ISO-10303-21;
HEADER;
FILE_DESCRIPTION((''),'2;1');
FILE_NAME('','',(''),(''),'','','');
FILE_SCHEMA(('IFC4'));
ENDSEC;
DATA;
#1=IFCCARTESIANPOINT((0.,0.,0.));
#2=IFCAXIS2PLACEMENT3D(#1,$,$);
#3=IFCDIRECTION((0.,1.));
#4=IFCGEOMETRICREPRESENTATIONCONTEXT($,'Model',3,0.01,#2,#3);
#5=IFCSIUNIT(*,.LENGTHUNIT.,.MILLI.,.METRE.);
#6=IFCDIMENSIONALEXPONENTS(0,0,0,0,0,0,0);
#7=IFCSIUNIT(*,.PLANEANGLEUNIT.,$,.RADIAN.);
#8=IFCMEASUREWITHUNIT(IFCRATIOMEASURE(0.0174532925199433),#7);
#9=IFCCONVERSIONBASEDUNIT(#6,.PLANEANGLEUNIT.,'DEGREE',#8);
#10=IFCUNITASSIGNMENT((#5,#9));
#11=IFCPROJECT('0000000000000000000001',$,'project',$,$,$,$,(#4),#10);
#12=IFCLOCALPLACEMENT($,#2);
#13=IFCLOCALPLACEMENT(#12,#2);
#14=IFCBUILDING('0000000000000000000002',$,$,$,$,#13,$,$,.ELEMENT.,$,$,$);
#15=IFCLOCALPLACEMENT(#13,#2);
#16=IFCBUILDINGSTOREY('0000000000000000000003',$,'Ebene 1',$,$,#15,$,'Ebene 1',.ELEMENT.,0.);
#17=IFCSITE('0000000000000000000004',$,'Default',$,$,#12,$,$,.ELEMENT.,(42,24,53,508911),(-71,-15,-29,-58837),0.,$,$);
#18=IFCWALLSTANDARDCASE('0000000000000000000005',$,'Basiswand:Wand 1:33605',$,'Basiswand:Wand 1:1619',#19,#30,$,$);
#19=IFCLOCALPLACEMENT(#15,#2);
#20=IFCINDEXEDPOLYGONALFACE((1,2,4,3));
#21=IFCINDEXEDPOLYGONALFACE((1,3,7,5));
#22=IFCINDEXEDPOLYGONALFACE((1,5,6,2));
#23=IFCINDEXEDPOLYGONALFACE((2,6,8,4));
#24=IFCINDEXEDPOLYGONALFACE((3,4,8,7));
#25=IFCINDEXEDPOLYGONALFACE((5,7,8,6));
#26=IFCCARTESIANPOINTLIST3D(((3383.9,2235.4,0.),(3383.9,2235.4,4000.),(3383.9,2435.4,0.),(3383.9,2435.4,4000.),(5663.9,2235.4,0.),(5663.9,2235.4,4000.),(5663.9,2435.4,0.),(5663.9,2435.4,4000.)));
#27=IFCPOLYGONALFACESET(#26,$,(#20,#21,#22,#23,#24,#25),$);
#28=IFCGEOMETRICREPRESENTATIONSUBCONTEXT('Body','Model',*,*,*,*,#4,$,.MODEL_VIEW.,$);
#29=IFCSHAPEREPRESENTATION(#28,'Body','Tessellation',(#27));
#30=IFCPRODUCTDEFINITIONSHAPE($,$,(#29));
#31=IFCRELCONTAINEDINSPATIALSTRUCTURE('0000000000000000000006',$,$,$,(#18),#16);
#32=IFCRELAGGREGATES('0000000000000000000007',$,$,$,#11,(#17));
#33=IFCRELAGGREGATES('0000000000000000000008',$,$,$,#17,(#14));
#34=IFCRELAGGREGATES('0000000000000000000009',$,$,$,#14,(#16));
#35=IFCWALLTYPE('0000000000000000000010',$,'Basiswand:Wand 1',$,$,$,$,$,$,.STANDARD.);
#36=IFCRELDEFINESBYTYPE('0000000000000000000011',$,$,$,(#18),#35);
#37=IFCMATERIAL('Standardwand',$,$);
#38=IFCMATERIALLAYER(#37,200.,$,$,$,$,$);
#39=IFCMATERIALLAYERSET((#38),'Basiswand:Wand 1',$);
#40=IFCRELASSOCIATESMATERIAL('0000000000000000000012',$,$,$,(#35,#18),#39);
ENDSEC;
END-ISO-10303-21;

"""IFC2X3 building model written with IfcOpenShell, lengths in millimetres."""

from ifc_helpers import new_model, entity, si_unit, converted_unit, direction, frame, frame_2d, origin, place, context, subcontext, project, spatial, rectangle, extrude, material, layer, layer_set, layer_usage, type_object, element, save


model = new_model("IFC2X3")

# Units and contexts
model_context = context("Model", 3, precision=0.01, world=origin(), true_north=direction((0.0, 1.0)))
body_context = subcontext(model_context, "Body", "Model", "MODEL_VIEW")
ifc_project = project(units=[si_unit("LENGTHUNIT", "METRE", prefix="MILLI"), converted_unit("PLANEANGLEUNIT", "DEGREE", entity("IfcRatioMeasure", 0.0174532925199433), si_unit("PLANEANGLEUNIT", "RADIAN"), dimensions=[0, 0, 0, 0, 0, 0, 0])], contexts=[model_context])

# Site, building, storey
site_placement = place(None, origin())
site = spatial("IfcSite", under=ifc_project, at=site_placement, Name="Default", CompositionType="ELEMENT", RefLatitude=(42, 24, 53, 508911), RefLongitude=(-71, -15, -29, -58837), RefElevation=0.0)
building_placement = place(site_placement, origin())
building = spatial("IfcBuilding", under=site, at=building_placement, CompositionType="ELEMENT")
storey_placement = place(building_placement, origin())
storey = spatial("IfcBuildingStorey", under=building, at=storey_placement, Name="Ebene 1", LongName="Ebene 1", CompositionType="ELEMENT", Elevation=0.0)

# Wall
ifc_material = material(Name="Standardwand")
ifc_layer = layer(ifc_material, 200.0)
ifc_layer_set = layer_set([ifc_layer], Name="Basiswand:Wand 1")
ifc_layer_usage = layer_usage(ifc_layer_set, "AXIS2", "NEGATIVE", 100.0)
wall_type = type_object("IfcWallType", Name="Basiswand:Wand 1", PredefinedType="STANDARD", material=ifc_layer_set)
wall_placement = place(storey_placement, frame((3383.9, 2335.4, 0.0)))
element("IfcWallStandardCase", 1, at=wall_placement, inside=storey, type_object=wall_type, material=ifc_layer_usage, Name="Basiswand:Wand 1:33605", ObjectType="Basiswand:Wand 1:1619", context=body_context, shape_type="SweptSolid", body=[
    extrude(rectangle(XDim=2280.0, YDim=200.0, at=frame_2d((1140.0, 0.0), x_axis=(-1.0, 0.0))), origin(), (0.0, 0.0, 1.0), 4000.0),
])

save(model, "model.ifc")
